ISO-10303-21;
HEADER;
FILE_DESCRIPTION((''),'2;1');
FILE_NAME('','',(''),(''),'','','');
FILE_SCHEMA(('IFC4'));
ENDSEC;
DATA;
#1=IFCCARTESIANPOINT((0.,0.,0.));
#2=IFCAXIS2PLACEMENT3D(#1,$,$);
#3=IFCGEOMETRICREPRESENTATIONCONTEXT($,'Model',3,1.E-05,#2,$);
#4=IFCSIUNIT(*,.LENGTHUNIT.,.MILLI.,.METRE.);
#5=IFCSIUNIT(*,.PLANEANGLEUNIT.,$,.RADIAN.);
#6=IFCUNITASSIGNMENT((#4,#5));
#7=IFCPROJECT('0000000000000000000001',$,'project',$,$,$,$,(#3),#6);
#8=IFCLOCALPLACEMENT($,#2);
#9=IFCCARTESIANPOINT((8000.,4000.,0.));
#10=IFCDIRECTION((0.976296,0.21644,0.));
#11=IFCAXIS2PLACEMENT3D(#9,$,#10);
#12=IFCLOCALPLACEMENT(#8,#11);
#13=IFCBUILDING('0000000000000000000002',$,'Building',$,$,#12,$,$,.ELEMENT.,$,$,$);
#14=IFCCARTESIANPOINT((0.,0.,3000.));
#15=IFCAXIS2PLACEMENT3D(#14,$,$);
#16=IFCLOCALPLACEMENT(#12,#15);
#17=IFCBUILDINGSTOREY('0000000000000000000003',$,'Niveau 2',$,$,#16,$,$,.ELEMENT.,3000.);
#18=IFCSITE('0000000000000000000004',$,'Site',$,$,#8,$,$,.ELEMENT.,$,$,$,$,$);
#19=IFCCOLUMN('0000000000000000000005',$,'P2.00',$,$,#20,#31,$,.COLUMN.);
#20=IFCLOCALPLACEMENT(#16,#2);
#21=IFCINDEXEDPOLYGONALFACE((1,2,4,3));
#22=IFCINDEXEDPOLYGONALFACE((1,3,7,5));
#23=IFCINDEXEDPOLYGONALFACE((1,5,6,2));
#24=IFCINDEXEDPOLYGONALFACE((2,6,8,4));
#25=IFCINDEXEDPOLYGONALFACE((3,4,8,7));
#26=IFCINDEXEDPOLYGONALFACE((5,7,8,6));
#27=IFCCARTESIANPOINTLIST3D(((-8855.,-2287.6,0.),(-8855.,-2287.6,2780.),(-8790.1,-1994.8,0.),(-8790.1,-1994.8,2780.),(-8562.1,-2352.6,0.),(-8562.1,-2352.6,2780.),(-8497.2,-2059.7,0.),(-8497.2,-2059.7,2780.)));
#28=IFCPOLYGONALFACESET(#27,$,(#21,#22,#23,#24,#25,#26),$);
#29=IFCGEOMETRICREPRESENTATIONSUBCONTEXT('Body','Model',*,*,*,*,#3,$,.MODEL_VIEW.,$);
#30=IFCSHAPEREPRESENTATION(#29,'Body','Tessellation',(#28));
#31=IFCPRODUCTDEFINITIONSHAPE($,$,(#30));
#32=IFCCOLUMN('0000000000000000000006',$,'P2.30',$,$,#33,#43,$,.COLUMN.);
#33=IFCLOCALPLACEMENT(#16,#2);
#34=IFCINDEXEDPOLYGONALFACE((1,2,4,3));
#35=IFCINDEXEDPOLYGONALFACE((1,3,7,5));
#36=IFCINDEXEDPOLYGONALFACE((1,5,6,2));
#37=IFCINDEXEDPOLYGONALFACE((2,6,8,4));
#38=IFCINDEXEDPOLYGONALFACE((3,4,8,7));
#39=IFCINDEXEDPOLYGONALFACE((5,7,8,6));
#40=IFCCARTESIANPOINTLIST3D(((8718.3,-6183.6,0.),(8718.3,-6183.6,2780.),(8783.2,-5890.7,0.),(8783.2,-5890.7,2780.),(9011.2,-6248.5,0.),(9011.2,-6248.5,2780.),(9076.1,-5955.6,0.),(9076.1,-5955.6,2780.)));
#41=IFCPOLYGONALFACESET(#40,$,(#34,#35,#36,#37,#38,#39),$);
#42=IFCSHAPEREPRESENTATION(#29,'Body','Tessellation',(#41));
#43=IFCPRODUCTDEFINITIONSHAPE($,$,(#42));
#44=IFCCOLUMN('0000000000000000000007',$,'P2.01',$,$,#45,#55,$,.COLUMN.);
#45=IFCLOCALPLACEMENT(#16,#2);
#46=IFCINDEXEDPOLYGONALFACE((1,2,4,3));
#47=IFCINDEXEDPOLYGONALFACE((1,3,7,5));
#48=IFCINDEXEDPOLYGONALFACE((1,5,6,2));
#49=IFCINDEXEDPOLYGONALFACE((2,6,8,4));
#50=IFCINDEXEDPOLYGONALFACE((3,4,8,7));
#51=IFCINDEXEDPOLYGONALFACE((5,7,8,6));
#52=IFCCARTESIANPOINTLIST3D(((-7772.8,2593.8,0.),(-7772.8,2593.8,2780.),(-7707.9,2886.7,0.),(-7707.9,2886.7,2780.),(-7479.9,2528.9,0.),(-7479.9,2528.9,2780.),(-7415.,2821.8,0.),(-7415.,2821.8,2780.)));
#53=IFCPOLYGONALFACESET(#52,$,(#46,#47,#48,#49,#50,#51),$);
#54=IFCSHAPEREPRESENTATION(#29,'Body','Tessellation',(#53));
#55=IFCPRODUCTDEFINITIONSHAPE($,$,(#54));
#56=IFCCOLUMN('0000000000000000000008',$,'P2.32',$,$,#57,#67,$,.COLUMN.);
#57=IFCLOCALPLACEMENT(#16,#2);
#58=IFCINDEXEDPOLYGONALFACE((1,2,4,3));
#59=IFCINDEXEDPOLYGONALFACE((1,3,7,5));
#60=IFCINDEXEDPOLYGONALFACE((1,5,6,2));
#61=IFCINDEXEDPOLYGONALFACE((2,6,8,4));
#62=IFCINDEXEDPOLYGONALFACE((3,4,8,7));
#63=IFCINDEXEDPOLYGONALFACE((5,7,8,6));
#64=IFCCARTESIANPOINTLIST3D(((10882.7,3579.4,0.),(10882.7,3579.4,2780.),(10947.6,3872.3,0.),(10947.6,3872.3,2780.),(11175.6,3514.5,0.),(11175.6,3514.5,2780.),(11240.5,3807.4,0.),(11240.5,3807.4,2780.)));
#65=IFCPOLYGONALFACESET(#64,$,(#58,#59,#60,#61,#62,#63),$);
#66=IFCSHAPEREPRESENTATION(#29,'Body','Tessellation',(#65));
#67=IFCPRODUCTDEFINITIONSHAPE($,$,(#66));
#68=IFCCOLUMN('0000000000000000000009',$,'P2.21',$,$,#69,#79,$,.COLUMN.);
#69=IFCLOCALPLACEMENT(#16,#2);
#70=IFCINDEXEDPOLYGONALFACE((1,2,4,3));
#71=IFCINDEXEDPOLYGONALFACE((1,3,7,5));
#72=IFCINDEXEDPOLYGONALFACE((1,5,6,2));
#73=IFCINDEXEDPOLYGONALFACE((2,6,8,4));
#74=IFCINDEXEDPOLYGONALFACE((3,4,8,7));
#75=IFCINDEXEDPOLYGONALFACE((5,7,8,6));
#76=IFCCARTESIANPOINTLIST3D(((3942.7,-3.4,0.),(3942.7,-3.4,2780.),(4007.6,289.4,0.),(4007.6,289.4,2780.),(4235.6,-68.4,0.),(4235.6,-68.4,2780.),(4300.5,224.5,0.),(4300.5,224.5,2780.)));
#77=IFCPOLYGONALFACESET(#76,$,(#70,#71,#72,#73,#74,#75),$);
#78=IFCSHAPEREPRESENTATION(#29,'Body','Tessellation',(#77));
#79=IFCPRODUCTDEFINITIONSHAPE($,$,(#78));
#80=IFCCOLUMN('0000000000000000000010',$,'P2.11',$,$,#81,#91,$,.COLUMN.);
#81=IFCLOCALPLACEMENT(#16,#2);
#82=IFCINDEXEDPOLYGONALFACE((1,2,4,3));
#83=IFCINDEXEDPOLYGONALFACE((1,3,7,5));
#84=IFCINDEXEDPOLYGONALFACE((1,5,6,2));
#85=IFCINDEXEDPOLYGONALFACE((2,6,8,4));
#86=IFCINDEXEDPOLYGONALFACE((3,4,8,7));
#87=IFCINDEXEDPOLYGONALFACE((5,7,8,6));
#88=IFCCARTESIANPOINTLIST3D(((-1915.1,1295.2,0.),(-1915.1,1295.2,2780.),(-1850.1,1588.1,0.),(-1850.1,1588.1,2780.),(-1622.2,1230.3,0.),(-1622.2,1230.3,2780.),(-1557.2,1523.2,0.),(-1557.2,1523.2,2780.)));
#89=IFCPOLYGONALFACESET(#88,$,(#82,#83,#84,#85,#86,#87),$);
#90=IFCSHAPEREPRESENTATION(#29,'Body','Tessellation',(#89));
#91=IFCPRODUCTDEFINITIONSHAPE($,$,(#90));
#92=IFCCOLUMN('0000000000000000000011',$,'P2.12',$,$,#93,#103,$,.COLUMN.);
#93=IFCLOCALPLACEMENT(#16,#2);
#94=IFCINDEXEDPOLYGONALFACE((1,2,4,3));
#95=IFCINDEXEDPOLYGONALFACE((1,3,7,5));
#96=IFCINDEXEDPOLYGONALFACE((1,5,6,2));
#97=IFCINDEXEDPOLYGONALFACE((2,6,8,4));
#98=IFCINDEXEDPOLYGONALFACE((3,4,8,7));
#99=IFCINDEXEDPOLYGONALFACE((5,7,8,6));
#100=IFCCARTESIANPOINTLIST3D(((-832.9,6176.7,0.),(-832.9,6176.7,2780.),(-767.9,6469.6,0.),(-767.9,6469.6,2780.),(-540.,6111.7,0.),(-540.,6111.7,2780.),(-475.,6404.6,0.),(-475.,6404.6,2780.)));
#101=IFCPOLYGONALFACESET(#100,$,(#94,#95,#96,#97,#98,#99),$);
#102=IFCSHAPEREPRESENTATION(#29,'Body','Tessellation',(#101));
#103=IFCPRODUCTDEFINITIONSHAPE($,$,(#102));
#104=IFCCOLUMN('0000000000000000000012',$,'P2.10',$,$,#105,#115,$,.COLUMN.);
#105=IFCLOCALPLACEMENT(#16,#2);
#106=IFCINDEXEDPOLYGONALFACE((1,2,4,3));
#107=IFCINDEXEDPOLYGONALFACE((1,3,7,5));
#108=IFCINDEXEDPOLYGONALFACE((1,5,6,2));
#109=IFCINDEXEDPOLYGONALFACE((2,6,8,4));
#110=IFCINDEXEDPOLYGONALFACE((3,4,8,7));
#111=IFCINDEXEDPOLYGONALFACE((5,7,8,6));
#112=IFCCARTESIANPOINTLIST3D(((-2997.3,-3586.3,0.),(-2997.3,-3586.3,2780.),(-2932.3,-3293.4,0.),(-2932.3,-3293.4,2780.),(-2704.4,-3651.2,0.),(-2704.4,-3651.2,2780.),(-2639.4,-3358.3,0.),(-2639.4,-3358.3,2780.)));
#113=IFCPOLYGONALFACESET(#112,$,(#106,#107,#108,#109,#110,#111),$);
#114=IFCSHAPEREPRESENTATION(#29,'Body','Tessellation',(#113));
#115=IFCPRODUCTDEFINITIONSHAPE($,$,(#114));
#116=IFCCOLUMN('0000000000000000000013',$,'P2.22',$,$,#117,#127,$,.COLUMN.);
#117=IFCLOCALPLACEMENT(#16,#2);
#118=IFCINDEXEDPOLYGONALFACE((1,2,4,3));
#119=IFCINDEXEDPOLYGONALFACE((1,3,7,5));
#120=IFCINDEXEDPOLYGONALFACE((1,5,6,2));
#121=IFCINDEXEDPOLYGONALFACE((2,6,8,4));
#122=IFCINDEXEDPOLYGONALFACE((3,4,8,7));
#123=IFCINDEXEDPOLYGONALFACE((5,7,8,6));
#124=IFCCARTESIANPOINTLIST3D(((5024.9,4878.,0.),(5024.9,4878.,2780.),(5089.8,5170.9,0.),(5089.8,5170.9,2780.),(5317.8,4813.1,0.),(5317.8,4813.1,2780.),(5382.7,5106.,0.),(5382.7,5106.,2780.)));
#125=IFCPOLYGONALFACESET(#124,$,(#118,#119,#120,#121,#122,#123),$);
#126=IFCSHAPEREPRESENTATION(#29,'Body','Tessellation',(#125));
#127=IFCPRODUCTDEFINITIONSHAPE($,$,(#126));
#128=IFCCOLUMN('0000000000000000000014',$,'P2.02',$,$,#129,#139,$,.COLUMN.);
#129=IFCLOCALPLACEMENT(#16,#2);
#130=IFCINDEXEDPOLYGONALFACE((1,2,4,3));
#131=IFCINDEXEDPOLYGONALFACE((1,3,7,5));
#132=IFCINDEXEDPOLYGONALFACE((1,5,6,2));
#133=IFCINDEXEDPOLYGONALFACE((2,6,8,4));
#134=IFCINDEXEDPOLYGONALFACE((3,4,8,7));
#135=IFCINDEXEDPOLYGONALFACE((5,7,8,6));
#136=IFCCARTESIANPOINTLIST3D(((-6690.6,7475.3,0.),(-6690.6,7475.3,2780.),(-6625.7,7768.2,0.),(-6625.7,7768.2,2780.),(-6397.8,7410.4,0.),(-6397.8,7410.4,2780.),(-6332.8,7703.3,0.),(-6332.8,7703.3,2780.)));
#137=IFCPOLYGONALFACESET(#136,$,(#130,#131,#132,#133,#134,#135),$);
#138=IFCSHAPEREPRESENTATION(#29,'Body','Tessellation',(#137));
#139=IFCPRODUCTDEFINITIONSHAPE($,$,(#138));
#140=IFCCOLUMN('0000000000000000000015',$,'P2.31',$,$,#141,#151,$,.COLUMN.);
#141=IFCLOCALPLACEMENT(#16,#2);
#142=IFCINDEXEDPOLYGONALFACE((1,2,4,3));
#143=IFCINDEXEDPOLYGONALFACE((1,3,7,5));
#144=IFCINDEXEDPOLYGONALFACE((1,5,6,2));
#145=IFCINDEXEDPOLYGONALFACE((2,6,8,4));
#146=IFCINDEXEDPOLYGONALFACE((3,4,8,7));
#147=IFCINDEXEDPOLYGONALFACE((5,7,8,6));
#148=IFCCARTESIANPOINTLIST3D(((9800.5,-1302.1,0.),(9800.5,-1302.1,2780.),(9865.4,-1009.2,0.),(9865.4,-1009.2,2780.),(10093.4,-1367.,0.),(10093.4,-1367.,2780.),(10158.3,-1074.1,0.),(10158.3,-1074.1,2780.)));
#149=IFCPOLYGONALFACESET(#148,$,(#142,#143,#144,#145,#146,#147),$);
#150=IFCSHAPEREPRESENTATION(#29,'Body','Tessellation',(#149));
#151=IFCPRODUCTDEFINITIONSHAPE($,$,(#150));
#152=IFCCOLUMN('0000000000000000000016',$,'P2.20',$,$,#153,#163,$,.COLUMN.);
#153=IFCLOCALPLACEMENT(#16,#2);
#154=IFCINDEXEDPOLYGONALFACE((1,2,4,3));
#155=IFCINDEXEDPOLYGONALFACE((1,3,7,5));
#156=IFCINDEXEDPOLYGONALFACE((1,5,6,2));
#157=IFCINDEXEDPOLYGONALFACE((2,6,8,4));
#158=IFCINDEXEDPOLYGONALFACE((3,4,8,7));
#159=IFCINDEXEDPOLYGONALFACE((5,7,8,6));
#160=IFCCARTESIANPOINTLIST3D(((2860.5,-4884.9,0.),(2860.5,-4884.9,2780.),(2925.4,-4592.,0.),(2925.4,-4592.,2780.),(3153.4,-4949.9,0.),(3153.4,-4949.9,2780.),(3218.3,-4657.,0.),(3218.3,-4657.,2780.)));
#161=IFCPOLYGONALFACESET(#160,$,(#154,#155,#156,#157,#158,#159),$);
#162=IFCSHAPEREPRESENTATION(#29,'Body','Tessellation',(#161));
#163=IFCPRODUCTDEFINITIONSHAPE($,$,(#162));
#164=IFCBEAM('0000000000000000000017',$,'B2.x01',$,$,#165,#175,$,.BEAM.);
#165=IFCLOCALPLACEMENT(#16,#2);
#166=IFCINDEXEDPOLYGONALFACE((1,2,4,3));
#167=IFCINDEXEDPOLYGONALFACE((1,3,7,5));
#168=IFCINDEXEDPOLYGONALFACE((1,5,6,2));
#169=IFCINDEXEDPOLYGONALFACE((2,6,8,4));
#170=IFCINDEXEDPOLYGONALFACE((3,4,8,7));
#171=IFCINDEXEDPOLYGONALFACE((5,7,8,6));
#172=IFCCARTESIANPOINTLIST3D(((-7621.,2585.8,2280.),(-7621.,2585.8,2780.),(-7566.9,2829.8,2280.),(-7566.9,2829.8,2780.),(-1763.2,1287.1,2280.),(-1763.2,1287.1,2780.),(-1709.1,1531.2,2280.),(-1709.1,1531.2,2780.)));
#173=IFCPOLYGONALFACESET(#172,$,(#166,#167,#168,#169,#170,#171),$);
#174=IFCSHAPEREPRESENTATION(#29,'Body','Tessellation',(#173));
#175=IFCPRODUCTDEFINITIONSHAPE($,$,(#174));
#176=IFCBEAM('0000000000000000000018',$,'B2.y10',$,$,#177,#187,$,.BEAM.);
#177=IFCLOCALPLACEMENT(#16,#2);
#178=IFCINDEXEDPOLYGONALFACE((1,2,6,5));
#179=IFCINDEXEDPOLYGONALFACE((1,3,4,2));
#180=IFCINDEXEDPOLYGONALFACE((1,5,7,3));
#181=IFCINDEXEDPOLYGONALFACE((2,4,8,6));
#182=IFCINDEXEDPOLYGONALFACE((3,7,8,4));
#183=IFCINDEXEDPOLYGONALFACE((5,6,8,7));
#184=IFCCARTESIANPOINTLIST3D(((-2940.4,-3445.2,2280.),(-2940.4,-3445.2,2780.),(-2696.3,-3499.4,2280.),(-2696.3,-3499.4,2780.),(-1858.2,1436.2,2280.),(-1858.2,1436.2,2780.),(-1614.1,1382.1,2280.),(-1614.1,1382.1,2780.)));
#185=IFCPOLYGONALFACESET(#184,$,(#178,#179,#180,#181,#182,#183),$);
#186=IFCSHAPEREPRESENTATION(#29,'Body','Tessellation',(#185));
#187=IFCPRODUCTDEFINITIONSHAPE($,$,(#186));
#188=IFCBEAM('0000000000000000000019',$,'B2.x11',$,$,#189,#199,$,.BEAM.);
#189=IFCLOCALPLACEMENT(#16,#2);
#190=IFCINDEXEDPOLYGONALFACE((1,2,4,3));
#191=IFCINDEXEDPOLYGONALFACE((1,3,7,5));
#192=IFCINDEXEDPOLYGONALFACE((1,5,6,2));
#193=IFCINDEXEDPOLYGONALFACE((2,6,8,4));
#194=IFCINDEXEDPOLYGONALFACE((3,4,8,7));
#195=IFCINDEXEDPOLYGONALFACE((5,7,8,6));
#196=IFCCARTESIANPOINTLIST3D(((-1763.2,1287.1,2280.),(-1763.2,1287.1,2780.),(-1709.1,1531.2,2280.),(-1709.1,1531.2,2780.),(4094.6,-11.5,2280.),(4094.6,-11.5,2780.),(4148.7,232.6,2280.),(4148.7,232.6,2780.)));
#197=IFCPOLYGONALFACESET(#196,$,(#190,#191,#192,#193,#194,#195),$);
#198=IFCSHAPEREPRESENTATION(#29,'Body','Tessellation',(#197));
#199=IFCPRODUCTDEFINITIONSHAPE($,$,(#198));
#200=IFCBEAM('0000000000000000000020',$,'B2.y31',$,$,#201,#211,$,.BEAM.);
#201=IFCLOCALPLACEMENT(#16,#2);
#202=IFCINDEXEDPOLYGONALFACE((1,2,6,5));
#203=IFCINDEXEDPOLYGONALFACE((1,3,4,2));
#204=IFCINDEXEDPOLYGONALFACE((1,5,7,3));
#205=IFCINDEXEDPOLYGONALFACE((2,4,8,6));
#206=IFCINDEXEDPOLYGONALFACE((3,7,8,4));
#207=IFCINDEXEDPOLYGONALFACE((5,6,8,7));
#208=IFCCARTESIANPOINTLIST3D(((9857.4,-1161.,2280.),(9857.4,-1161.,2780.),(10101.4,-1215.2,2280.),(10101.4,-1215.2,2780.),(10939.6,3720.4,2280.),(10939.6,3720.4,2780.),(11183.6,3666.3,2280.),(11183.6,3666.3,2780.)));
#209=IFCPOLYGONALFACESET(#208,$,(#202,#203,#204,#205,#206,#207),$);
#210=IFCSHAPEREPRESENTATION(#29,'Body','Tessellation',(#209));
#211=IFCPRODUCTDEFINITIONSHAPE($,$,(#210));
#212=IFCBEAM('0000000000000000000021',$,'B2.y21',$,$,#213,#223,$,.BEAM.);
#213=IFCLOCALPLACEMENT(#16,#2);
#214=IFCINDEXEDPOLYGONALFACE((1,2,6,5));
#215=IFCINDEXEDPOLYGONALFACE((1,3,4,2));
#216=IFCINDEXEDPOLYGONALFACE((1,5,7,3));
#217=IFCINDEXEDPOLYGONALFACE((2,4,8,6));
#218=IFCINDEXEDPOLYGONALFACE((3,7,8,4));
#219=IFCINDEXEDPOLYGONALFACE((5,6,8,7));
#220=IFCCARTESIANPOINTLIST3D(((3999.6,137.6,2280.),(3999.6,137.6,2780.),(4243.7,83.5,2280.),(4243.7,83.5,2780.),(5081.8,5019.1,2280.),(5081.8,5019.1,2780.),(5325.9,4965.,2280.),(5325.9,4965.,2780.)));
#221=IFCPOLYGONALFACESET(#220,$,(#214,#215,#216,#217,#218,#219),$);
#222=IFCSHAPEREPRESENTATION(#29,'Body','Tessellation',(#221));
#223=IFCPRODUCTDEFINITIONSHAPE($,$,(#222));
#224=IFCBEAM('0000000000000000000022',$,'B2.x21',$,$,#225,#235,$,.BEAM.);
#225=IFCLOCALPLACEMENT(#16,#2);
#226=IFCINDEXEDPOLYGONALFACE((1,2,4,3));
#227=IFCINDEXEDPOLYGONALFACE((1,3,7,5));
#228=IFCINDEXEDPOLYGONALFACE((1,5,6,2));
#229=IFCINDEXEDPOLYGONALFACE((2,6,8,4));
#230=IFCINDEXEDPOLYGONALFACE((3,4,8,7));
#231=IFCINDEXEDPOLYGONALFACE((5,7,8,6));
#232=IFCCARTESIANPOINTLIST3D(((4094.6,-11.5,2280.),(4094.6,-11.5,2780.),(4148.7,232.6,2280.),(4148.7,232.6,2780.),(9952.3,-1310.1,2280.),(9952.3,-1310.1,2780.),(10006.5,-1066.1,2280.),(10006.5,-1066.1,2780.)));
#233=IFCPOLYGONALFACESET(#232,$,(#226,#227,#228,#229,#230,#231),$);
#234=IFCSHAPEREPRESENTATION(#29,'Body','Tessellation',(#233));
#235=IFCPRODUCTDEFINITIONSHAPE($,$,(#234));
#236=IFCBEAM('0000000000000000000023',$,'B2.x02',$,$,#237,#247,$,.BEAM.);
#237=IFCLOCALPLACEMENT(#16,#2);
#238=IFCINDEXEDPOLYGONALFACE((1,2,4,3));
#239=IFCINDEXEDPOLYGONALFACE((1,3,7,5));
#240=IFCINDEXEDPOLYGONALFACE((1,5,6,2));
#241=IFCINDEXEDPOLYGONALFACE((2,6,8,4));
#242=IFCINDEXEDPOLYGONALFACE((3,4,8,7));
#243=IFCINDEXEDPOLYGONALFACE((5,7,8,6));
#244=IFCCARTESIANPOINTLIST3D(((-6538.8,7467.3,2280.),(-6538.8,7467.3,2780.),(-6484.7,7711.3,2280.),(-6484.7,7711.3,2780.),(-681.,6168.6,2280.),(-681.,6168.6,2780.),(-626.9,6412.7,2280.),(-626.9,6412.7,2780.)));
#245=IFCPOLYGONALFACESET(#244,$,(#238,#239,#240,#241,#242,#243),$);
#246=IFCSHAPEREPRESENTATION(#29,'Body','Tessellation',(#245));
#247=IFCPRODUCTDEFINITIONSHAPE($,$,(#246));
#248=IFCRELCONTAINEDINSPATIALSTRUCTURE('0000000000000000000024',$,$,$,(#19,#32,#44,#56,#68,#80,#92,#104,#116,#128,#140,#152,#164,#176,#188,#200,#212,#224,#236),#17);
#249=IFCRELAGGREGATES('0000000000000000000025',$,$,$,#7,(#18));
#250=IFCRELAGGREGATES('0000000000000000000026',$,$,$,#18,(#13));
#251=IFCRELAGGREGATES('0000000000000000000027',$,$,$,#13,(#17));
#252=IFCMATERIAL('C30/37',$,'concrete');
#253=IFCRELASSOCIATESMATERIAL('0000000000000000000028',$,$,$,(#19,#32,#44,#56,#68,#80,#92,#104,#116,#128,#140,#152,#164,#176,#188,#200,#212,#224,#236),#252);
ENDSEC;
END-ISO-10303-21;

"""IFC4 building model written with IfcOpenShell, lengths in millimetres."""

from ifc_helpers import new_model, si_unit, frame, origin, place, context, subcontext, project, spatial, rectangle, extrude, material, element, save


model = new_model("IFC4")

# Units and contexts
model_context = context("Model", 3, precision=1e-05, world=origin())
body_context = subcontext(model_context, "Body", "Model", "MODEL_VIEW")
ifc_project = project(units=[si_unit("LENGTHUNIT", "METRE", prefix="MILLI"), si_unit("PLANEANGLEUNIT", "RADIAN")], contexts=[model_context])

# Site, building, storey
site_placement = place(None, origin())
site = spatial("IfcSite", under=ifc_project, at=site_placement, Name="Site", CompositionType="ELEMENT")
building_placement = place(site_placement, frame((8000.0, 4000.0, 0.0), x_axis=(0.976296, 0.21644, 0.0)))
building = spatial("IfcBuilding", under=site, at=building_placement, Name="Building", CompositionType="ELEMENT")
storey_placement = place(building_placement, frame((0.0, 0.0, 3000.0)))
storey = spatial("IfcBuildingStorey", under=building, at=storey_placement, Name="Niveau 2", CompositionType="ELEMENT", Elevation=3000.0)

# Columns
ifc_material = material(Name="C30/37", Category="concrete")
for number, where, z_axis, x_axis, name in (
    (1, (-8676.1, -2173.7, 0.0), (0.0, 0.0, 1.0), (0.976296, -0.21644, 0.0), "P2.00"),
    (2, (8897.2, -6069.6, 0.0), (0.0, 0.0, 1.0), (0.976296, -0.21644, 0.0), "P2.30"),
    (3, (-7593.9, 2707.8, 0.0), (0.0, 0.0, 1.0), (0.976296, -0.21644, 0.0), "P2.01"),
    (4, (11061.6, 3693.4, 0.0), (0.0, 0.0, 1.0), (0.976296, -0.21644, 0.0), "P2.32"),
    (5, (4121.6, 110.5, 0.0), (0.0, 0.0, 1.0), (0.976296, -0.21644, 0.0), "P2.21"),
    (6, (-1736.2, 1409.2, 0.0), (0.0, 0.0, 1.0), (0.976296, -0.21644, 0.0), "P2.11"),
    (7, (-654.0, 6290.7, 0.0), (0.0, 0.0, 1.0), (0.976296, -0.21644, 0.0), "P2.12"),
    (8, (-2818.4, -3472.3, 0.0), (0.0, 0.0, 1.0), (0.976296, -0.21644, 0.0), "P2.10"),
    (9, (5203.8, 4992.0, 0.0), (0.0, 0.0, 1.0), (0.976296, -0.21644, 0.0), "P2.22"),
    (10, (-6511.7, 7589.3, 0.0), (0.0, 0.0, 1.0), (0.976296, -0.21644, 0.0), "P2.02"),
    (11, (9979.4, -1188.1, 0.0), (0.0, 0.0, 1.0), (0.976296, -0.21644, 0.0), "P2.31"),
    (12, (3039.4, -4770.9, 0.0), (0.0, 0.0, 1.0), (0.976296, -0.21644, 0.0), "P2.20"),
):
    element("IfcColumn", number, at=place(storey_placement, frame(where, z_axis=z_axis, x_axis=x_axis)), inside=storey, material=ifc_material, Name=name, PredefinedType="COLUMN", context=body_context, shape_type="SweptSolid", body=[
        extrude(rectangle(XDim=300.0, YDim=300.0), origin(), (0.0, 0.0, 1.0), 2780.0),
    ])

# Beams
beam_1_placement = place(storey_placement, frame((-7593.9, 2707.8, 2530.0), z_axis=(0.976296, -0.21644, 0.0), x_axis=(0.21644, 0.976296, 0.0)))
element("IfcBeam", 13, at=beam_1_placement, inside=storey, material=ifc_material, Name="B2.x01", PredefinedType="BEAM", context=body_context, shape_type="SweptSolid", body=[
    extrude(rectangle(XDim=250.0, YDim=500.0), origin(), (0.0, 0.0, 1.0), 6000.0),
])
beam_2_placement = place(storey_placement, frame((-2818.4, -3472.3, 2530.0), z_axis=(0.21644, 0.976296, 0.0), x_axis=(-0.976296, 0.21644, 0.0)))
element("IfcBeam", 14, at=beam_2_placement, inside=storey, material=ifc_material, Name="B2.y10", PredefinedType="BEAM", context=body_context, shape_type="SweptSolid", body=[
    extrude(rectangle(XDim=250.0, YDim=500.0), origin(), (0.0, 0.0, 1.0), 5000.0),
])
beam_3_placement = place(storey_placement, frame((-1736.2, 1409.2, 2530.0), z_axis=(0.976296, -0.21644, 0.0), x_axis=(0.21644, 0.976296, 0.0)))
element("IfcBeam", 15, at=beam_3_placement, inside=storey, material=ifc_material, Name="B2.x11", PredefinedType="BEAM", context=body_context, shape_type="SweptSolid", body=[
    extrude(rectangle(XDim=250.0, YDim=500.0), origin(), (0.0, 0.0, 1.0), 6000.0),
])
for number, where, z_axis, x_axis, name in (
    (16, (9979.4, -1188.1, 2530.0), (0.21644, 0.976296, 0.0), (-0.976296, 0.21644, 0.0), "B2.y31"),
    (17, (4121.6, 110.5, 2530.0), (0.21644, 0.976296, 0.0), (-0.976296, 0.21644, 0.0), "B2.y21"),
):
    element("IfcBeam", number, at=place(storey_placement, frame(where, z_axis=z_axis, x_axis=x_axis)), inside=storey, material=ifc_material, Name=name, PredefinedType="BEAM", context=body_context, shape_type="SweptSolid", body=[
        extrude(rectangle(XDim=250.0, YDim=500.0), origin(), (0.0, 0.0, 1.0), 5000.0),
    ])
for number, where, z_axis, x_axis, name in (
    (18, (4121.6, 110.5, 2530.0), (0.976296, -0.21644, 0.0), (0.21644, 0.976296, 0.0), "B2.x21"),
    (19, (-6511.7, 7589.3, 2530.0), (0.976296, -0.21644, 0.0), (0.21644, 0.976296, 0.0), "B2.x02"),
):
    element("IfcBeam", number, at=place(storey_placement, frame(where, z_axis=z_axis, x_axis=x_axis)), inside=storey, material=ifc_material, Name=name, PredefinedType="BEAM", context=body_context, shape_type="SweptSolid", body=[
        extrude(rectangle(XDim=250.0, YDim=500.0), origin(), (0.0, 0.0, 1.0), 6000.0),
    ])

save(model, "model.ifc")
